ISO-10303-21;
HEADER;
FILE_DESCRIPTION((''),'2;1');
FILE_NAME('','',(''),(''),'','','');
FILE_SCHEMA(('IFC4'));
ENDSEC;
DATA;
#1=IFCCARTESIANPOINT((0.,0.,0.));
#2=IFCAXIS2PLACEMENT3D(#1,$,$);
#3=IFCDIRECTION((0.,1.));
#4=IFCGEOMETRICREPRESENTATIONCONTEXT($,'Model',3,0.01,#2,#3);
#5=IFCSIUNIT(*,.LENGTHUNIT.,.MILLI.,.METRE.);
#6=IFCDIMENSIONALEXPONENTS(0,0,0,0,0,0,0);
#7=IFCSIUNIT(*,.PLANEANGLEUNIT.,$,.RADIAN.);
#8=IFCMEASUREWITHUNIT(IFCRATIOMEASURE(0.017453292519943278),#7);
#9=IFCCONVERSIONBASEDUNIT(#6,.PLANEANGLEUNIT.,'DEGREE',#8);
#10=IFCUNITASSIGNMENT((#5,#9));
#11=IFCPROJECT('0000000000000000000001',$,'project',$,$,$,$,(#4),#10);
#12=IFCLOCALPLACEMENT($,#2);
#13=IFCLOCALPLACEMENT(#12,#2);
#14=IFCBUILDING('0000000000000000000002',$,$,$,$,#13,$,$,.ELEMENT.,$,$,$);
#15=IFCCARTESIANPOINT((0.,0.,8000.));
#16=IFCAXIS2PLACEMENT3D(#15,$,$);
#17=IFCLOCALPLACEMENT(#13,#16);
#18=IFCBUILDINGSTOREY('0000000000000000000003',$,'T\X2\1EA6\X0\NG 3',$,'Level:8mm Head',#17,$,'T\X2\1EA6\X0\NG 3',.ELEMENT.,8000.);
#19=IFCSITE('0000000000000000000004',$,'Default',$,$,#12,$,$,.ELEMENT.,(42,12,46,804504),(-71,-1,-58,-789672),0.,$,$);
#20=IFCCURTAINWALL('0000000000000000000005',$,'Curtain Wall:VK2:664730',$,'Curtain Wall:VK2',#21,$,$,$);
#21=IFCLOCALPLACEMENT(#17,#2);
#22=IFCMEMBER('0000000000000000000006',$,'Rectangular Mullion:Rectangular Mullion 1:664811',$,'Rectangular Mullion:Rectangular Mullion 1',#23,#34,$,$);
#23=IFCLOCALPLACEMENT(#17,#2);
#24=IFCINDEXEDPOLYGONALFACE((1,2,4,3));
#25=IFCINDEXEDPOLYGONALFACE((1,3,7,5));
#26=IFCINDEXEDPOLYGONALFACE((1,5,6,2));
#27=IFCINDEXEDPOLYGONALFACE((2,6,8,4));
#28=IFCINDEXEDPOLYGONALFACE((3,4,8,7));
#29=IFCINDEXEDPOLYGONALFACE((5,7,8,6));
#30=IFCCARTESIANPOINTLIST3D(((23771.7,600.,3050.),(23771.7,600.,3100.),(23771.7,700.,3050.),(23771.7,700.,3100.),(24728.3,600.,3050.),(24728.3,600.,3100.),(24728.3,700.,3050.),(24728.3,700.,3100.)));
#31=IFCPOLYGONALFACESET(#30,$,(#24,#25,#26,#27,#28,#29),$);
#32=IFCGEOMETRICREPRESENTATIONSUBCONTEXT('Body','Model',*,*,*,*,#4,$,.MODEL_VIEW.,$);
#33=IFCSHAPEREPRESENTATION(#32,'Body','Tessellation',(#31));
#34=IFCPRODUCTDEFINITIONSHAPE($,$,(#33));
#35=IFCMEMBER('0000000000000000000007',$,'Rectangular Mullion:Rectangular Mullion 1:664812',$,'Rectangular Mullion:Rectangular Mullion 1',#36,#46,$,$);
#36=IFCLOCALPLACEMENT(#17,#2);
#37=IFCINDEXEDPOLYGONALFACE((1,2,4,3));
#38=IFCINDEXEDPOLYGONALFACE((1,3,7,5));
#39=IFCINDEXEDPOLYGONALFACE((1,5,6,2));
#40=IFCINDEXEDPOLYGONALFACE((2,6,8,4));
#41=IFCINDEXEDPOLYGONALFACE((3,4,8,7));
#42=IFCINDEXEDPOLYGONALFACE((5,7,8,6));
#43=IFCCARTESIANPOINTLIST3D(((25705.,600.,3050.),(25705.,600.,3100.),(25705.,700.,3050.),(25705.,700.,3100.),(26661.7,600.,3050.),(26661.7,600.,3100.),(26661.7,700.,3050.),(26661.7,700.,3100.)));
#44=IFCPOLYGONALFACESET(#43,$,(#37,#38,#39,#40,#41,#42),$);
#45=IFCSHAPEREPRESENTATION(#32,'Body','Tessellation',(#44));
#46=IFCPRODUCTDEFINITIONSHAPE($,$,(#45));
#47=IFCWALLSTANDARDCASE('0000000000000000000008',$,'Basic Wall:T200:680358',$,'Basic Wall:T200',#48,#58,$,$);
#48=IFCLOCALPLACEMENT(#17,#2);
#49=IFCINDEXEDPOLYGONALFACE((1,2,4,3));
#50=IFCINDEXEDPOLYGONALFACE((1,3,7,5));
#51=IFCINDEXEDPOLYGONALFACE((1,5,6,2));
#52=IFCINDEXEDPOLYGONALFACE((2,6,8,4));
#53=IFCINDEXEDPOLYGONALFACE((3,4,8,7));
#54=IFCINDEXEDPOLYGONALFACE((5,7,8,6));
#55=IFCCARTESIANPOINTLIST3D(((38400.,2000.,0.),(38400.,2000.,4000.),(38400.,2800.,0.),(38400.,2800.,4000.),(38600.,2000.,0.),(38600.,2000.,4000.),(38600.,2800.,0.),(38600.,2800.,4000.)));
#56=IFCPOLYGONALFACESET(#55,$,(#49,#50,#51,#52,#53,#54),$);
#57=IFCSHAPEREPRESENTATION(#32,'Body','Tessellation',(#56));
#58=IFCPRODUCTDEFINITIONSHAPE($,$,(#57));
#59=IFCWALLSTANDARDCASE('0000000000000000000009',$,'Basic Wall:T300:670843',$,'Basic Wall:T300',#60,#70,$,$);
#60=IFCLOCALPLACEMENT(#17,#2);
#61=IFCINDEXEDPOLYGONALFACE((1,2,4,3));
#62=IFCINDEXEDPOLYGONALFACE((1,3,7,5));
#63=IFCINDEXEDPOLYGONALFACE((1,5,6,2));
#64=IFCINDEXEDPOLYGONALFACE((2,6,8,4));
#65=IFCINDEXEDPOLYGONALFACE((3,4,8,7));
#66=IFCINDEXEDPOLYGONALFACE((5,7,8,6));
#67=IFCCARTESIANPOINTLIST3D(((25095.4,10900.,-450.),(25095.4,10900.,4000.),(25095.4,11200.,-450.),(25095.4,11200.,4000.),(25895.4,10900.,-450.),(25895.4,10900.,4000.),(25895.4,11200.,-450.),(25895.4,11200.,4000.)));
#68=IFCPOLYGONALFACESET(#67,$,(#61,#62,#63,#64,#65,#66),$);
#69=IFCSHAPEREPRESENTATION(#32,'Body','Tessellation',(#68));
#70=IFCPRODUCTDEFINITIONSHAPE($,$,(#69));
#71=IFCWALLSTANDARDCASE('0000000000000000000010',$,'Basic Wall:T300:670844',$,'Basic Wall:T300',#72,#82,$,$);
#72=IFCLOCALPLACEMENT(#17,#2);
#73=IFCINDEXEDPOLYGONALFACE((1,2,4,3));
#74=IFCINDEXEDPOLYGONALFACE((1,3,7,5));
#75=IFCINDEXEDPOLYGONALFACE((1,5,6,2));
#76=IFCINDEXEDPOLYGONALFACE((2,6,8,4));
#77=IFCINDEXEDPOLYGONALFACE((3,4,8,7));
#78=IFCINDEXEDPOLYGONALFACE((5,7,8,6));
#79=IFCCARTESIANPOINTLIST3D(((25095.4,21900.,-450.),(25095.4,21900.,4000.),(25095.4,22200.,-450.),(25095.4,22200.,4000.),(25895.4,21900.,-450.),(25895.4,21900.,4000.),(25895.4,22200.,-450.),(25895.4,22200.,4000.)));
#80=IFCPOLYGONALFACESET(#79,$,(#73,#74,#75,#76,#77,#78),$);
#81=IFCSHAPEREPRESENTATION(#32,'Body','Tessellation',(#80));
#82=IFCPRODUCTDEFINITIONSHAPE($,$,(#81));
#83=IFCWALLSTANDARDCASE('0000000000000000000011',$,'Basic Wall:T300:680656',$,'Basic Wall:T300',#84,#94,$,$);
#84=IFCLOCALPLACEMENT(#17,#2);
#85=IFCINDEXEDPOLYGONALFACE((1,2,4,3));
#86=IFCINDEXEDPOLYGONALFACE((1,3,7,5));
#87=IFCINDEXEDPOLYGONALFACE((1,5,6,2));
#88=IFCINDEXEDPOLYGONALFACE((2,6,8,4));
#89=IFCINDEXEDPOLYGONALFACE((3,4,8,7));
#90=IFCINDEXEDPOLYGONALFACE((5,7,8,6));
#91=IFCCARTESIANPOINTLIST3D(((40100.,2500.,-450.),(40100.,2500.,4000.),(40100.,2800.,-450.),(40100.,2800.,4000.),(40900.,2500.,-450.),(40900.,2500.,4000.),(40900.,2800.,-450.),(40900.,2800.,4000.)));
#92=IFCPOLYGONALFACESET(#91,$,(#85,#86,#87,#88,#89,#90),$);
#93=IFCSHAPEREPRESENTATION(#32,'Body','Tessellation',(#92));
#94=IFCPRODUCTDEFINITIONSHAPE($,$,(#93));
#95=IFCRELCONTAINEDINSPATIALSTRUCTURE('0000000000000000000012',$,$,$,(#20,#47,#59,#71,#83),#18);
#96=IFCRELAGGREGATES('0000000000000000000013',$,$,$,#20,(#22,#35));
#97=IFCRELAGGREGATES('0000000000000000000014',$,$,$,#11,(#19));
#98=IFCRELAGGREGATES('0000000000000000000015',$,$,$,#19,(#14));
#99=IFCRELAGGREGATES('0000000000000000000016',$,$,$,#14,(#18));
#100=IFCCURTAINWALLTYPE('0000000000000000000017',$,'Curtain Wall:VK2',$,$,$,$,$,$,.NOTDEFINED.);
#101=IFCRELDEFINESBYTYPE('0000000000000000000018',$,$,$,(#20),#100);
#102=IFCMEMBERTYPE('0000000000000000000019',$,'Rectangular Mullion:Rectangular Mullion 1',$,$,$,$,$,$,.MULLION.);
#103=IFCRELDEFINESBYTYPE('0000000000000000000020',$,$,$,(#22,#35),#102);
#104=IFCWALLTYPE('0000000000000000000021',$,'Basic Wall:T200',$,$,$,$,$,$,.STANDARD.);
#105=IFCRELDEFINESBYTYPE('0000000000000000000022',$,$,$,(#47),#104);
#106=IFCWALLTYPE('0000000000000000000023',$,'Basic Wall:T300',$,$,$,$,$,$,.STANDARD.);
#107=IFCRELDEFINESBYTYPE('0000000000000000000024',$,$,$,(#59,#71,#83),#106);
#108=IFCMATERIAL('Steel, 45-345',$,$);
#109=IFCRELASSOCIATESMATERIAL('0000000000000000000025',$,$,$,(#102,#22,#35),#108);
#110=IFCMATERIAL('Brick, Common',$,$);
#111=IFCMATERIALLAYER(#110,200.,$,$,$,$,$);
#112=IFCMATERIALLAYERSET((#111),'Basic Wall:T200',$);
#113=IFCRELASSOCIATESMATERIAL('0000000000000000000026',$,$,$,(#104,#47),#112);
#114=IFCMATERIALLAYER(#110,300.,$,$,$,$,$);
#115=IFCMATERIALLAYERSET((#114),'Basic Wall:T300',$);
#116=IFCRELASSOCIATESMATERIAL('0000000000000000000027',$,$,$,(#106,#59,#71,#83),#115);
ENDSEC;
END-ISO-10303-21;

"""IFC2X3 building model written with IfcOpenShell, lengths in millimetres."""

from ifc_helpers import new_model, entity, si_unit, converted_unit, direction, frame, frame_2d, origin, origin_2d_with_axis, place, context, subcontext, project, spatial, rectangle, extrude, source, transform, mapped, material, layer, layer_set, layer_usage, type_object, type_shapes, element, aggregate, save


model = new_model("IFC2X3")

# Units and contexts
model_context = context("Model", 3, precision=0.01, world=origin(), true_north=direction((0.0, 1.0)))
body_context = subcontext(model_context, "Body", "Model", "MODEL_VIEW")
ifc_project = project(units=[si_unit("LENGTHUNIT", "METRE", prefix="MILLI"), converted_unit("PLANEANGLEUNIT", "DEGREE", entity("IfcRatioMeasure", 0.017453292519943278), si_unit("PLANEANGLEUNIT", "RADIAN"), dimensions=[0, 0, 0, 0, 0, 0, 0])], contexts=[model_context])

# Site, building, storey
site_placement = place(None, origin())
site = spatial("IfcSite", under=ifc_project, at=site_placement, Name="Default", CompositionType="ELEMENT", RefLatitude=(42, 12, 46, 804504), RefLongitude=(-71, -1, -58, -789672), RefElevation=0.0)
building_placement = place(site_placement, origin())
building = spatial("IfcBuilding", under=site, at=building_placement, CompositionType="ELEMENT")
storey_placement = place(building_placement, frame((0.0, 0.0, 8000.0)))
storey = spatial("IfcBuildingStorey", under=building, at=storey_placement, Name="TẦNG 3", ObjectType="Level:8mm Head", LongName="TẦNG 3", CompositionType="ELEMENT", Elevation=8000.0)

# Curtain wall, members
curtain_wall_type = type_object("IfcCurtainWallType", Name="Curtain Wall:VK2", PredefinedType="NOTDEFINED")
curtain_wall_1_placement = place(storey_placement, frame((0.0, 0.0, -8000.0)))
curtain_wall_1 = element("IfcCurtainWall", 1, at=curtain_wall_1_placement, inside=storey, type_object=curtain_wall_type, Name="Curtain Wall:VK2:664730", ObjectType="Curtain Wall:VK2")
ifc_material_1 = material(Name="Steel, 45-345")
member_type_1 = type_object("IfcMemberType", Name="Rectangular Mullion:Rectangular Mullion 1", PredefinedType="MULLION", material=ifc_material_1)
shared_shape_1 = source(origin(), body_context, "Body", "SweptSolid", [
    extrude(rectangle(XDim=100.0, YDim=50.0, at=origin_2d_with_axis()), frame((-25.0, 50.0, -956.7), z_axis=(0.0, 0.0, 1.0), x_axis=(0.0, -1.0, 0.0)), (0.0, 0.0, 1.0), 956.7),
])
type_shapes(member_type_1, [shared_shape_1])
member_1_placement = place(curtain_wall_1_placement, frame((24728.3, 700.0, 11100.0), z_axis=(1.0, 0.0, 0.0), x_axis=(0.0, 0.0, 1.0)))
member_1 = element("IfcMember", 2, at=member_1_placement, type_object=member_type_1, material=ifc_material_1, Name="Rectangular Mullion:Rectangular Mullion 1:664811", ObjectType="Rectangular Mullion:Rectangular Mullion 1", context=body_context, shape_type="MappedRepresentation", body=[
    mapped(shared_shape_1, transform((0.0, 0.0, 0.0), scale=1.0)),
])
member_2_placement = place(curtain_wall_1_placement, frame((26661.7, 700.0, 11100.0), z_axis=(1.0, 0.0, 0.0), x_axis=(0.0, 0.0, 1.0)))
member_2 = element("IfcMember", 3, at=member_2_placement, type_object=member_type_1, material=ifc_material_1, Name="Rectangular Mullion:Rectangular Mullion 1:664812", ObjectType="Rectangular Mullion:Rectangular Mullion 1", context=body_context, shape_type="MappedRepresentation", body=[
    mapped(shared_shape_1, transform((0.0, 0.0, 0.0), scale=1.0)),
])
aggregate(curtain_wall_1, [member_1, member_2])

# Wall
ifc_material_2 = material(Name="Brick, Common")
ifc_layer_1 = layer(ifc_material_2, 200.0)
ifc_layer_set_1 = layer_set([ifc_layer_1], Name="Basic Wall:T200")
ifc_layer_usage_1 = layer_usage(ifc_layer_set_1, "AXIS2", "POSITIVE", -100.0)
wall_type_1 = type_object("IfcWallType", Name="Basic Wall:T200", PredefinedType="STANDARD", material=ifc_layer_set_1)
wall_1_placement = place(storey_placement, frame((38500.0, 2800.0, 0.0), z_axis=(0.0, 0.0, 1.0), x_axis=(0.0, -1.0, 0.0)))
element("IfcWallStandardCase", 4, at=wall_1_placement, inside=storey, type_object=wall_type_1, material=ifc_layer_usage_1, Name="Basic Wall:T200:680358", ObjectType="Basic Wall:T200", context=body_context, shape_type="SweptSolid", body=[
    extrude(rectangle(XDim=800.0, YDim=200.0, at=frame_2d((400.0, 0.0), x_axis=(-1.0, 0.0))), origin(), (0.0, 0.0, 1.0), 4000.0),
])

# Walls
ifc_layer_2 = layer(ifc_material_2, 300.0)
ifc_layer_set_2 = layer_set([ifc_layer_2], Name="Basic Wall:T300")
ifc_layer_usage_2 = layer_usage(ifc_layer_set_2, "AXIS2", "NEGATIVE", 150.0)
wall_type_2 = type_object("IfcWallType", Name="Basic Wall:T300", PredefinedType="STANDARD", material=ifc_layer_set_2)
wall_2_placement = place(storey_placement, frame((25895.4, 11050.0, -450.0), z_axis=(0.0, 0.0, 1.0), x_axis=(-1.0, 0.0, 0.0)))
element("IfcWallStandardCase", 5, at=wall_2_placement, inside=storey, type_object=wall_type_2, material=ifc_layer_usage_2, Name="Basic Wall:T300:670843", ObjectType="Basic Wall:T300", context=body_context, shape_type="SweptSolid", body=[
    extrude(rectangle(XDim=800.0, YDim=300.0, at=frame_2d((400.0, 0.0), x_axis=(-1.0, 0.0))), origin(), (0.0, 0.0, 1.0), 4450.0),
])
ifc_layer_usage_3 = layer_usage(ifc_layer_set_2, "AXIS2", "POSITIVE", -150.0)
wall_3_placement = place(storey_placement, frame((25895.4, 22050.0, -450.0), z_axis=(0.0, 0.0, 1.0), x_axis=(-1.0, 0.0, 0.0)))
element("IfcWallStandardCase", 6, at=wall_3_placement, inside=storey, type_object=wall_type_2, material=ifc_layer_usage_3, Name="Basic Wall:T300:670844", ObjectType="Basic Wall:T300", context=body_context, shape_type="SweptSolid", body=[
    extrude(rectangle(XDim=800.0, YDim=300.0, at=frame_2d((400.0, 0.0), x_axis=(-1.0, 0.0))), origin(), (0.0, 0.0, 1.0), 4450.0),
])
wall_4_placement = place(storey_placement, frame((40900.0, 2650.0, -450.0), z_axis=(0.0, 0.0, 1.0), x_axis=(-1.0, 0.0, 0.0)))
element("IfcWallStandardCase", 7, at=wall_4_placement, inside=storey, type_object=wall_type_2, material=ifc_layer_usage_3, Name="Basic Wall:T300:680656", ObjectType="Basic Wall:T300", context=body_context, shape_type="SweptSolid", body=[
    extrude(rectangle(XDim=800.0, YDim=300.0, at=frame_2d((400.0, 0.0), x_axis=(-1.0, 0.0))), origin(), (0.0, 0.0, 1.0), 4450.0),
])

save(model, "model.ifc")
